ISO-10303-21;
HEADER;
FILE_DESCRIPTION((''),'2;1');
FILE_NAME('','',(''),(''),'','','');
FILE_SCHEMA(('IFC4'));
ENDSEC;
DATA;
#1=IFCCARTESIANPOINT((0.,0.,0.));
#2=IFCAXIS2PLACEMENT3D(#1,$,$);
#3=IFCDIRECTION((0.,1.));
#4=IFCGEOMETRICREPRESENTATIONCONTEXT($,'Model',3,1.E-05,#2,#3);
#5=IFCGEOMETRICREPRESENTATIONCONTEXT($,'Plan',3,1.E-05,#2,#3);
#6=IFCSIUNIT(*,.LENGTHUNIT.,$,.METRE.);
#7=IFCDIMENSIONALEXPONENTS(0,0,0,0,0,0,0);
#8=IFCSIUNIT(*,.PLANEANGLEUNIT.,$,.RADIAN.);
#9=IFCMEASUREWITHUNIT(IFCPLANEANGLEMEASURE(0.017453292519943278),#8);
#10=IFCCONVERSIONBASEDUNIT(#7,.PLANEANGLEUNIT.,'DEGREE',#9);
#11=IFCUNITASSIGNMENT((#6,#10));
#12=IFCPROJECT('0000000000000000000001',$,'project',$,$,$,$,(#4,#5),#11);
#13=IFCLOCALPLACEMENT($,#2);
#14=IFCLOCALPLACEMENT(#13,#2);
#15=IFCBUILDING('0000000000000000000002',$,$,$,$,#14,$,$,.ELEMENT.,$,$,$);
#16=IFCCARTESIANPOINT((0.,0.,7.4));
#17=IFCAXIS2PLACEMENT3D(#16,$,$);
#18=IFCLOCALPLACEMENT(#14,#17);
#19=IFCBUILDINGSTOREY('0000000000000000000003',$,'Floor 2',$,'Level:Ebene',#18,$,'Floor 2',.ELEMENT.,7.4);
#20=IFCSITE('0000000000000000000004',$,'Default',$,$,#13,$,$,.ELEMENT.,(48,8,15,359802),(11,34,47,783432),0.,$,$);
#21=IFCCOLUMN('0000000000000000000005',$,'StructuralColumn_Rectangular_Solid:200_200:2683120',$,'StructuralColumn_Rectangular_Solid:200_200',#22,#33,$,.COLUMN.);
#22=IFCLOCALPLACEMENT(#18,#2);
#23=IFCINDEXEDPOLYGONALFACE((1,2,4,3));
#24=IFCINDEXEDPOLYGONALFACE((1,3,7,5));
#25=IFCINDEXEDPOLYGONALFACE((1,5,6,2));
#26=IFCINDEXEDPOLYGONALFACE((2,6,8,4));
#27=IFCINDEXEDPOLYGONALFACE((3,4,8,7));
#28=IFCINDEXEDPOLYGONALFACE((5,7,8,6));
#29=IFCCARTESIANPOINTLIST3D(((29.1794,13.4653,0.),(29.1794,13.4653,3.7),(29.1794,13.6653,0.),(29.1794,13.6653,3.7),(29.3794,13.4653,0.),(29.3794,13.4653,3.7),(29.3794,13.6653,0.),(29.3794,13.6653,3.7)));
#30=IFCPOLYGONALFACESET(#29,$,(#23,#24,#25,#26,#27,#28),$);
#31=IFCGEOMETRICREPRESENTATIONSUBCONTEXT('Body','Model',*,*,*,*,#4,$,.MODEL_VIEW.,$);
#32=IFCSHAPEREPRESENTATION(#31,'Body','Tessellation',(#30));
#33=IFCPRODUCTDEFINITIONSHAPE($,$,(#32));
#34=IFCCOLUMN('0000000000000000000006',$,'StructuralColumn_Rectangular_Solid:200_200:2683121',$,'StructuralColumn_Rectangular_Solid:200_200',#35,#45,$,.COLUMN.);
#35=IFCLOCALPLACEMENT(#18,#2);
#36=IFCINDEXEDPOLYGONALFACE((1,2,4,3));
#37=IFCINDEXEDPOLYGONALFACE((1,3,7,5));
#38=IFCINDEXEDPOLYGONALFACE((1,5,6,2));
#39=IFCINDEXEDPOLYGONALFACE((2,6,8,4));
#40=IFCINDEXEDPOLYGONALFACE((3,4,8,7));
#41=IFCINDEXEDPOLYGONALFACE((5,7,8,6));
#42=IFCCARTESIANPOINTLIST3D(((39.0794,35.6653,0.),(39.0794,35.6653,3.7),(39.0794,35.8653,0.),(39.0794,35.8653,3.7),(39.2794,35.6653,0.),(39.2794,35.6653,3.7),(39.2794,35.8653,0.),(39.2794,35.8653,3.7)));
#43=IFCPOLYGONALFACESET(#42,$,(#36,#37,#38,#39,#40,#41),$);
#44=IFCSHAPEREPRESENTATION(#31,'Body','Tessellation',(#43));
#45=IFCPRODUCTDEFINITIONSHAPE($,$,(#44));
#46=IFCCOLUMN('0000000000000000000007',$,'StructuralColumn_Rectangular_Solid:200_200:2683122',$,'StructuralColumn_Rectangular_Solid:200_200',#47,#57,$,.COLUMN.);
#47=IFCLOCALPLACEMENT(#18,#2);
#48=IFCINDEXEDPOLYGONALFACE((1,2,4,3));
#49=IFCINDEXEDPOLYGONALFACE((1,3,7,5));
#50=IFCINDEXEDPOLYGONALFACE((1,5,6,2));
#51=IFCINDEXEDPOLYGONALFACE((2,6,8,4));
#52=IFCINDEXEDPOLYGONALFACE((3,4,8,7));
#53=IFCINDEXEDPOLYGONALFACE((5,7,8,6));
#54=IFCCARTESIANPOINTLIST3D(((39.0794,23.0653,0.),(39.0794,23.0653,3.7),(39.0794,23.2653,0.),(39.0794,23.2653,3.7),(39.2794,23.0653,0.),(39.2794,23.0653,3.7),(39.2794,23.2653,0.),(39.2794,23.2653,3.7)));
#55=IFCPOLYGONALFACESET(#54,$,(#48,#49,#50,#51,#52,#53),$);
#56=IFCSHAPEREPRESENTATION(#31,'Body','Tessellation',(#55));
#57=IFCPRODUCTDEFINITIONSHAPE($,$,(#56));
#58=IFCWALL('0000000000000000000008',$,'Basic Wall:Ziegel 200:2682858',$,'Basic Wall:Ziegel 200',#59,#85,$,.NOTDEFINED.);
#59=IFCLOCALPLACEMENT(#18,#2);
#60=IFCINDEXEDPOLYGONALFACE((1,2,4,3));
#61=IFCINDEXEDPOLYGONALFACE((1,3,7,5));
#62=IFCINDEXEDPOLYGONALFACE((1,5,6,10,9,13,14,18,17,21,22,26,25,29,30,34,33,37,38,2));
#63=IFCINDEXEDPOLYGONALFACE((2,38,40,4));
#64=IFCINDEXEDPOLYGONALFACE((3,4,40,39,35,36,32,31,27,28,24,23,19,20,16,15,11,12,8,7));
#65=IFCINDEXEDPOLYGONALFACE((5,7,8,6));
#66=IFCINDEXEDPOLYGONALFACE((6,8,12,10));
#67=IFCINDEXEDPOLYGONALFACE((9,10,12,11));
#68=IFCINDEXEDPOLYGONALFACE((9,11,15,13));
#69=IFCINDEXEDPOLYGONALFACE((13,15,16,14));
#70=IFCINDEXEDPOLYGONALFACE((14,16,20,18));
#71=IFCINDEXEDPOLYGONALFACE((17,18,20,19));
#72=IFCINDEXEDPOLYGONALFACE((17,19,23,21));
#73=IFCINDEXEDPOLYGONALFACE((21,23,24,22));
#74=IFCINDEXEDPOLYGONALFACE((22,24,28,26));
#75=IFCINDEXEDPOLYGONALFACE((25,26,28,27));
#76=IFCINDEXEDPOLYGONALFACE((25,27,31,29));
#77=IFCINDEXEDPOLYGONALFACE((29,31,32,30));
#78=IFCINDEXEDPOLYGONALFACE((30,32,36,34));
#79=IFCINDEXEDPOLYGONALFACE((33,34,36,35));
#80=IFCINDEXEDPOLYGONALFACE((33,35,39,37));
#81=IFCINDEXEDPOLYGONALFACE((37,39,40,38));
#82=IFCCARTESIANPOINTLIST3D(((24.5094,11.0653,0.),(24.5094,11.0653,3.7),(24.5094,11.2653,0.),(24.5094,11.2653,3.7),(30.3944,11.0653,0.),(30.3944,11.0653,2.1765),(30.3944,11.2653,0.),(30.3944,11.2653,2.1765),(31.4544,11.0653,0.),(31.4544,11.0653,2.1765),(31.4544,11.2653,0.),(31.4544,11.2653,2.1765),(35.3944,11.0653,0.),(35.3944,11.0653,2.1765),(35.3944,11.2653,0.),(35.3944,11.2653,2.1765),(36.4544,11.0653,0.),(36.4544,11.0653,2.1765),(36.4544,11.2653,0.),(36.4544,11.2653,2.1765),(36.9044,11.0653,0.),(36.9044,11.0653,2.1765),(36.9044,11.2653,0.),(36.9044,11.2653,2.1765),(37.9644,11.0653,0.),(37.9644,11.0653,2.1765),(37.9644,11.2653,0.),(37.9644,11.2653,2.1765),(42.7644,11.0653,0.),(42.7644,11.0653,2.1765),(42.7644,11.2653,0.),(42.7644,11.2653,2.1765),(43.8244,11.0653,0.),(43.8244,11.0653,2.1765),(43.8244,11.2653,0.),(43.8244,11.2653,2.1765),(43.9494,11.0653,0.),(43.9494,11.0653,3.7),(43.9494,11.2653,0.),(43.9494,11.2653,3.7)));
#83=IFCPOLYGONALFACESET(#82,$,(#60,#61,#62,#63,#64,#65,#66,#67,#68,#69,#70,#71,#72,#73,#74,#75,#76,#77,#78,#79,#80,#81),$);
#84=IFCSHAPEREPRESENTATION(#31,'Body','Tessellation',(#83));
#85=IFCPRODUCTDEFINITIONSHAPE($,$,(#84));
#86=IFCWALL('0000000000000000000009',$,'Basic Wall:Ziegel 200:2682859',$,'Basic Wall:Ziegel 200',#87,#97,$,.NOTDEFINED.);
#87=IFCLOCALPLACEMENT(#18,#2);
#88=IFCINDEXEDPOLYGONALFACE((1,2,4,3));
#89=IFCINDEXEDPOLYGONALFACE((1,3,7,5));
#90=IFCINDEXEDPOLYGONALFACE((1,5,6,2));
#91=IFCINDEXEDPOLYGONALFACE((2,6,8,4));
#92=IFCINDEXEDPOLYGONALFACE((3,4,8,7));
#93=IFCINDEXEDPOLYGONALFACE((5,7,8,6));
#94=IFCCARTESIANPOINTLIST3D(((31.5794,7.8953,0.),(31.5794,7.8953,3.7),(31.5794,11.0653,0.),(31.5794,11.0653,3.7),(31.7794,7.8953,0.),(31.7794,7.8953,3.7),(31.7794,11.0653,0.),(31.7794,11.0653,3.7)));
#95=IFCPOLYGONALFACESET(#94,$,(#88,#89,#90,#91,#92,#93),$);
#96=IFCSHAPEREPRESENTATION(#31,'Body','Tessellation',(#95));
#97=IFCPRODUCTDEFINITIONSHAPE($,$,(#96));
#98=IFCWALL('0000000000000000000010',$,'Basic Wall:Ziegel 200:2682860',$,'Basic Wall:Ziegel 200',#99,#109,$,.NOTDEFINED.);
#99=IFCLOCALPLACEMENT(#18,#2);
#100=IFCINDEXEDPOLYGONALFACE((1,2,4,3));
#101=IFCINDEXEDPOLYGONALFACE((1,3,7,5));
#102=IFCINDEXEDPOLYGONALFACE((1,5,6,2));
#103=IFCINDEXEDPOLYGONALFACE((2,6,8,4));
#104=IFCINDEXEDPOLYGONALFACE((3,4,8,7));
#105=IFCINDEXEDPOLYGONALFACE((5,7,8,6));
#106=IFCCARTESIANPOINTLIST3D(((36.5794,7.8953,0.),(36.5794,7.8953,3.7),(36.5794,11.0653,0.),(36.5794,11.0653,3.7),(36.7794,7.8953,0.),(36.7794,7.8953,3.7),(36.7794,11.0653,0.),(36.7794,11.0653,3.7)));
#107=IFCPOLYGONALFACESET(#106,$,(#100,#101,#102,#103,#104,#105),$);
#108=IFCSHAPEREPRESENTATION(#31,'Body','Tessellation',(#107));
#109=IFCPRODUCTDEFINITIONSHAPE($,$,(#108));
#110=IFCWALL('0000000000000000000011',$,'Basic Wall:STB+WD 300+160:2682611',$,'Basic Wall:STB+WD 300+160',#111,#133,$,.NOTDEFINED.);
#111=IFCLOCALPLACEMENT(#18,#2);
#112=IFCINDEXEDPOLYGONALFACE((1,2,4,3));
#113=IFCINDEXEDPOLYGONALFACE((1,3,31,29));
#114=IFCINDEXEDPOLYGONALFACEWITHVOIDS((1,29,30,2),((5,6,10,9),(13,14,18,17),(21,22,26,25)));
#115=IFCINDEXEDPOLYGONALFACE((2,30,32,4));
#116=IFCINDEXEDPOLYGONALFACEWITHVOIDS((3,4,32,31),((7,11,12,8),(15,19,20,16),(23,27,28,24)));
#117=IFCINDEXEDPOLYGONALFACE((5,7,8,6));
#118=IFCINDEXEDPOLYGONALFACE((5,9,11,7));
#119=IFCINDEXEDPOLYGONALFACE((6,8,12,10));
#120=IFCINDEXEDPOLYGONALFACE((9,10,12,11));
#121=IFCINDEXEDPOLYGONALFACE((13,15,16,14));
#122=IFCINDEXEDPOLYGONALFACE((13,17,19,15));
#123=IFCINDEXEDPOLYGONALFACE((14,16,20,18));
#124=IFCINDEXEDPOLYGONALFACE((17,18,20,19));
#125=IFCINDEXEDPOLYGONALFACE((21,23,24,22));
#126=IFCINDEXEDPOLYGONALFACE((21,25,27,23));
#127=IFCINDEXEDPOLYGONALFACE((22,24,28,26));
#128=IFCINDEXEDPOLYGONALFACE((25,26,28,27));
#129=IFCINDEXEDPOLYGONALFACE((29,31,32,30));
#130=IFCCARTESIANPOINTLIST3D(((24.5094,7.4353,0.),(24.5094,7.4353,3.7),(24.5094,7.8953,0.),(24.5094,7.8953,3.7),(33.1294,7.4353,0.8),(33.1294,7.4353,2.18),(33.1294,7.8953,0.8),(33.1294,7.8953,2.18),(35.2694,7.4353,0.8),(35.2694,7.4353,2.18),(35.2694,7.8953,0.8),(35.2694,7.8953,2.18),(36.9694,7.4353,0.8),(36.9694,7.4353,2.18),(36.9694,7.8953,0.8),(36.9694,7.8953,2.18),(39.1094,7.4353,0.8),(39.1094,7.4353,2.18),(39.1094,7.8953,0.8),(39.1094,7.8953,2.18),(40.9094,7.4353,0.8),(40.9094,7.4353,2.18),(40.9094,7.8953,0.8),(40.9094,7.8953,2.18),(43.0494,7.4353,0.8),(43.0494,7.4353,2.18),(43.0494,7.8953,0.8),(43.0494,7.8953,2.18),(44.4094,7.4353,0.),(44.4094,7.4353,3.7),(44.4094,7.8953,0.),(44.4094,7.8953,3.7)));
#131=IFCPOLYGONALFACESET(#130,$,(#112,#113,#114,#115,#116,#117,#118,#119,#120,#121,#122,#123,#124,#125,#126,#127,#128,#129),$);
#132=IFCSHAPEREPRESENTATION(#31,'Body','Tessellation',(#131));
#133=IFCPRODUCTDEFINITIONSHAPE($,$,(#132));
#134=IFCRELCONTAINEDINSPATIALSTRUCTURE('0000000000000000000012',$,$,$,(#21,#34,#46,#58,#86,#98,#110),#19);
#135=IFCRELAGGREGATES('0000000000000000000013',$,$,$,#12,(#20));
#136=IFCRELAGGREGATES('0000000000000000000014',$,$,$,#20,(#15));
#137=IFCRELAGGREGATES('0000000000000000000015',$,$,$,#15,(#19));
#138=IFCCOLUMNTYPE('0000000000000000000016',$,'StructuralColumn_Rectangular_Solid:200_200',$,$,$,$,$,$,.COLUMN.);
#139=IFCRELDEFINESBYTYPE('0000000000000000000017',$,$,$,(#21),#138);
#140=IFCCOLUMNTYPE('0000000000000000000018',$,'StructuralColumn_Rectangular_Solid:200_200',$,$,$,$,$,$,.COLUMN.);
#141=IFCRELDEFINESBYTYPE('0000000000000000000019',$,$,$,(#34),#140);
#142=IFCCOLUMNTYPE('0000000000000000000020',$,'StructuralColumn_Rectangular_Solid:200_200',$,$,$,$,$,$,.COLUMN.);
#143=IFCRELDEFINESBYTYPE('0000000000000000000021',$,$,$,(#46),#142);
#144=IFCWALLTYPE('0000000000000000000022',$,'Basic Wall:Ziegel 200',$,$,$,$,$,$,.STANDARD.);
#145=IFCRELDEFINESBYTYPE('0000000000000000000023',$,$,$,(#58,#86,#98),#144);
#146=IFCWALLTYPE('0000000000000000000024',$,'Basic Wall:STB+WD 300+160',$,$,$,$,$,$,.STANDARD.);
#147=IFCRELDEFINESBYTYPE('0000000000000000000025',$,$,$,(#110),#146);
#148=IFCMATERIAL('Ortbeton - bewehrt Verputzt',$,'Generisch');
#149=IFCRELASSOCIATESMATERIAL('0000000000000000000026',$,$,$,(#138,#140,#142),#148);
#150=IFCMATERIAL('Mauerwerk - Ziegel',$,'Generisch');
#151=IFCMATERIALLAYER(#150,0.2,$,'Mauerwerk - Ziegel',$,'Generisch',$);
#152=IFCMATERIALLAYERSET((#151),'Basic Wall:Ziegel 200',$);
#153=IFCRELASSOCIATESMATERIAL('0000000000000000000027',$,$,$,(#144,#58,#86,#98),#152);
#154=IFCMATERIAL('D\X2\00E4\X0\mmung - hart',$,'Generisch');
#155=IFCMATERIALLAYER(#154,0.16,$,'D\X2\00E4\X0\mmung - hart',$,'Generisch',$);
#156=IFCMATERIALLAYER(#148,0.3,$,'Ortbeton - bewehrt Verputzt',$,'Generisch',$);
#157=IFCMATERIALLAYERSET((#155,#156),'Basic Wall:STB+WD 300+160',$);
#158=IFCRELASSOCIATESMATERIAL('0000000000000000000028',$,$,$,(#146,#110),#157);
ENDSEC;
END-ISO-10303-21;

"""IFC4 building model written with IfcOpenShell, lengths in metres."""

from ifc_helpers import new_model, entity, si_unit, converted_unit, direction, frame, frame_2d, origin, place, context, subcontext, project, spatial, rectangle, extrude, source, transform, mapped, material, layer, layer_set, layer_usage, material_profile, profile_set, type_object, type_shapes, element, save


model = new_model("IFC4")

# Units and contexts
model_context = context("Model", 3, precision=1e-05, world=origin(), true_north=direction((0.0, 1.0)))
plan_context = context("Plan", 3, precision=1e-05, world=origin(), true_north=direction((0.0, 1.0)))
body_context = subcontext(model_context, "Body", "Model", "MODEL_VIEW")
ifc_project = project(units=[si_unit("LENGTHUNIT", "METRE"), converted_unit("PLANEANGLEUNIT", "DEGREE", entity("IfcPlaneAngleMeasure", 0.017453292519943278), si_unit("PLANEANGLEUNIT", "RADIAN"), dimensions=[0, 0, 0, 0, 0, 0, 0])], contexts=[model_context, plan_context])

# Site, building, storey
site_placement = place(None, origin())
site = spatial("IfcSite", under=ifc_project, at=site_placement, Name="Default", CompositionType="ELEMENT", RefLatitude=(48, 8, 15, 359802), RefLongitude=(11, 34, 47, 783432), RefElevation=0.0)
building_placement = place(site_placement, origin())
building = spatial("IfcBuilding", under=site, at=building_placement, CompositionType="ELEMENT")
storey_placement = place(building_placement, frame((0.0, 0.0, 7.4)))
storey = spatial("IfcBuildingStorey", under=building, at=storey_placement, Name="Floor 2", ObjectType="Level:Ebene", LongName="Floor 2", CompositionType="ELEMENT", Elevation=7.4)

# Columns
ifc_material_1 = material(Name="Ortbeton - bewehrt Verputzt", Category="Generisch")
ifc_material_profile = material_profile(ifc_material_1, rectangle(XDim=0.2, YDim=0.2, at=frame_2d((0.0, 0.0), x_axis=(1.0, 0.0))), Name="200_200")
ifc_profile_set = profile_set([ifc_material_profile], Name="200_200")
column_type_1 = type_object("IfcColumnType", Name="StructuralColumn_Rectangular_Solid:200_200", PredefinedType="COLUMN", material=ifc_profile_set)
shared_shape_1 = source(origin(), body_context, "Body", "SweptSolid", [
    extrude(rectangle(XDim=0.2, YDim=0.2, at=frame_2d((0.0, 0.0), x_axis=(1.0, 0.0))), frame((29.2794, 13.5653, 7.4), z_axis=(0.0, 0.0, 1.0), x_axis=(-1.0, 0.0, 0.0)), (0.0, 0.0, 1.0), 3.7),
])
type_shapes(column_type_1, [shared_shape_1])
column_1_placement = place(storey_placement, frame((0.0, 0.0, -7.4)))
element("IfcColumn", 1, at=column_1_placement, inside=storey, type_object=column_type_1, Name="StructuralColumn_Rectangular_Solid:200_200:2683120", ObjectType="StructuralColumn_Rectangular_Solid:200_200", PredefinedType="COLUMN", context=body_context, shape_type="MappedRepresentation", body=[
    mapped(shared_shape_1, transform((0.0, 0.0, 0.0), scale=1.0)),
])
column_type_2 = type_object("IfcColumnType", Name="StructuralColumn_Rectangular_Solid:200_200", PredefinedType="COLUMN", material=ifc_profile_set)
shared_shape_2 = source(origin(), body_context, "Body", "SweptSolid", [
    extrude(rectangle(XDim=0.2, YDim=0.2, at=frame_2d((0.0, 0.0), x_axis=(1.0, 0.0))), frame((39.1794, 35.7653, 7.4), z_axis=(0.0, 0.0, 1.0), x_axis=(-1.0, 0.0, 0.0)), (0.0, 0.0, 1.0), 3.7),
])
type_shapes(column_type_2, [shared_shape_2])
column_2_placement = place(storey_placement, frame((0.0, 0.0, -7.4)))
element("IfcColumn", 2, at=column_2_placement, inside=storey, type_object=column_type_2, Name="StructuralColumn_Rectangular_Solid:200_200:2683121", ObjectType="StructuralColumn_Rectangular_Solid:200_200", PredefinedType="COLUMN", context=body_context, shape_type="MappedRepresentation", body=[
    mapped(shared_shape_2, transform((0.0, 0.0, 0.0), scale=1.0)),
])
column_type_3 = type_object("IfcColumnType", Name="StructuralColumn_Rectangular_Solid:200_200", PredefinedType="COLUMN", material=ifc_profile_set)
shared_shape_3 = source(origin(), body_context, "Body", "SweptSolid", [
    extrude(rectangle(XDim=0.2, YDim=0.2, at=frame_2d((0.0, 0.0), x_axis=(1.0, 0.0))), frame((39.1794, 23.1653, 7.4), z_axis=(0.0, 0.0, 1.0), x_axis=(-1.0, 0.0, 0.0)), (0.0, 0.0, 1.0), 3.7),
])
type_shapes(column_type_3, [shared_shape_3])
column_3_placement = place(storey_placement, frame((0.0, 0.0, -7.4)))
element("IfcColumn", 3, at=column_3_placement, inside=storey, type_object=column_type_3, Name="StructuralColumn_Rectangular_Solid:200_200:2683122", ObjectType="StructuralColumn_Rectangular_Solid:200_200", PredefinedType="COLUMN", context=body_context, shape_type="MappedRepresentation", body=[
    mapped(shared_shape_3, transform((0.0, 0.0, 0.0), scale=1.0)),
])

# Wall, openings
ifc_material_2 = material(Name="Mauerwerk - Ziegel", Category="Generisch")
ifc_layer_1 = layer(ifc_material_2, 0.2, Name="Mauerwerk - Ziegel", Category="Generisch")
ifc_layer_set_1 = layer_set([ifc_layer_1], Name="Basic Wall:Ziegel 200")
ifc_layer_usage_1 = layer_usage(ifc_layer_set_1, "AXIS2", "NEGATIVE", 0.1)
wall_type_1 = type_object("IfcWallType", Name="Basic Wall:Ziegel 200", PredefinedType="STANDARD", material=ifc_layer_set_1)
wall_1_placement = place(storey_placement, frame((43.9494, 11.1653, 0.0), z_axis=(0.0, 0.0, 1.0), x_axis=(-1.0, 0.0, 0.0)))
wall_1 = element("IfcWall", 4, at=wall_1_placement, inside=storey, type_object=wall_type_1, material=ifc_layer_usage_1, Name="Basic Wall:Ziegel 200:2682858", ObjectType="Basic Wall:Ziegel 200", PredefinedType="NOTDEFINED", context=body_context, shape_type="SweptSolid", body=[
    extrude(rectangle(XDim=19.44, YDim=0.2, at=frame_2d((9.72, 0.0), x_axis=(1.0, 0.0))), origin(), (0.0, 0.0, 1.0), 3.7),
])
opening_1_placement = place(wall_1_placement, frame((13.555, 0.1, 0.0)))
element("IfcOpeningElement", 5, at=opening_1_placement, cuts=wall_1, PredefinedType="OPENING", context=body_context, shape_type="SweptSolid", body=[
    extrude(rectangle(XDim=2.1765, YDim=1.06, at=frame_2d((1.0882, 0.53), x_axis=(1.0, 0.0))), frame((0.0, 0.0, 0.0), z_axis=(0.0, -1.0, 0.0), x_axis=(0.0, 0.0, 1.0)), (0.0, 0.0, 1.0), 0.2),
])
opening_2_placement = place(wall_1_placement, frame((8.555, 0.1, 0.0)))
element("IfcOpeningElement", 6, at=opening_2_placement, cuts=wall_1, PredefinedType="OPENING", context=body_context, shape_type="SweptSolid", body=[
    extrude(rectangle(XDim=2.1765, YDim=1.06, at=frame_2d((1.0882, 0.53), x_axis=(1.0, 0.0))), frame((0.0, 0.0, 0.0), z_axis=(0.0, -1.0, 0.0), x_axis=(0.0, 0.0, 1.0)), (0.0, 0.0, 1.0), 0.2),
])
opening_3_placement = place(wall_1_placement, frame((7.045, 0.1, 0.0)))
element("IfcOpeningElement", 7, at=opening_3_placement, cuts=wall_1, PredefinedType="OPENING", context=body_context, shape_type="SweptSolid", body=[
    extrude(rectangle(XDim=2.1765, YDim=1.06, at=frame_2d((1.0882, 0.53), x_axis=(1.0, 0.0))), frame((0.0, 0.0, 0.0), z_axis=(0.0, -1.0, 0.0), x_axis=(0.0, 0.0, 1.0)), (0.0, 0.0, 1.0), 0.2),
])
opening_4_placement = place(wall_1_placement, frame((1.185, 0.1, 0.0)))
element("IfcOpeningElement", 8, at=opening_4_placement, cuts=wall_1, PredefinedType="OPENING", context=body_context, shape_type="SweptSolid", body=[
    extrude(rectangle(XDim=2.1765, YDim=1.06, at=frame_2d((1.0882, 0.53), x_axis=(1.0, 0.0))), frame((0.0, 0.0, 0.0), z_axis=(0.0, -1.0, 0.0), x_axis=(0.0, 0.0, 1.0)), (0.0, 0.0, 1.0), 0.2),
])

# Walls
wall_2_placement = place(storey_placement, frame((31.6794, 11.0653, 0.0), z_axis=(0.0, 0.0, 1.0), x_axis=(0.0, -1.0, 0.0)))
element("IfcWall", 9, at=wall_2_placement, inside=storey, type_object=wall_type_1, material=ifc_layer_usage_1, Name="Basic Wall:Ziegel 200:2682859", ObjectType="Basic Wall:Ziegel 200", PredefinedType="NOTDEFINED", context=body_context, shape_type="SweptSolid", body=[
    extrude(rectangle(XDim=3.17, YDim=0.2, at=frame_2d((1.585, 0.0), x_axis=(-1.0, 0.0))), origin(), (0.0, 0.0, 1.0), 3.7),
])
wall_3_placement = place(storey_placement, frame((36.6794, 11.0653, 0.0), z_axis=(0.0, 0.0, 1.0), x_axis=(0.0, -1.0, 0.0)))
element("IfcWall", 10, at=wall_3_placement, inside=storey, type_object=wall_type_1, material=ifc_layer_usage_1, Name="Basic Wall:Ziegel 200:2682860", ObjectType="Basic Wall:Ziegel 200", PredefinedType="NOTDEFINED", context=body_context, shape_type="SweptSolid", body=[
    extrude(rectangle(XDim=3.17, YDim=0.2, at=frame_2d((1.585, 0.0), x_axis=(-1.0, 0.0))), origin(), (0.0, 0.0, 1.0), 3.7),
])

# Wall, openings
ifc_material_3 = material(Name="Dämmung - hart", Category="Generisch")
ifc_layer_2 = layer(ifc_material_3, 0.16, Name="Dämmung - hart", Category="Generisch")
ifc_layer_3 = layer(ifc_material_1, 0.3, Name="Ortbeton - bewehrt Verputzt", Category="Generisch")
ifc_layer_set_2 = layer_set([ifc_layer_2, ifc_layer_3], Name="Basic Wall:STB+WD 300+160")
ifc_layer_usage_2 = layer_usage(ifc_layer_set_2, "AXIS2", "POSITIVE", -0.23)
wall_type_2 = type_object("IfcWallType", Name="Basic Wall:STB+WD 300+160", PredefinedType="STANDARD", material=ifc_layer_set_2)
wall_4_placement = place(storey_placement, frame((24.5094, 7.6653, 0.0)))
wall_4 = element("IfcWall", 11, at=wall_4_placement, inside=storey, type_object=wall_type_2, material=ifc_layer_usage_2, Name="Basic Wall:STB+WD 300+160:2682611", ObjectType="Basic Wall:STB+WD 300+160", PredefinedType="NOTDEFINED", context=body_context, shape_type="SweptSolid", body=[
    extrude(rectangle(XDim=19.9, YDim=0.46, at=frame_2d((9.95, 0.0), x_axis=(-1.0, 0.0))), origin(), (0.0, 0.0, 1.0), 3.7),
])
opening_5_placement = place(wall_4_placement, frame((-24.5094, -7.6653, 0.8)))
element("IfcOpeningElement", 12, at=opening_5_placement, cuts=wall_4, PredefinedType="OPENING", context=body_context, shape_type="SweptSolid", body=[
    extrude(rectangle(XDim=1.38, YDim=2.14, at=frame_2d((0.0, 0.0), x_axis=(0.0, 1.0))), frame((34.1994, 6.3713, 0.69), z_axis=(0.0, 1.0, 0.0), x_axis=(-1.0, 0.0, 0.0)), (0.0, 0.0, 1.0), 3.048),
])
opening_6_placement = place(wall_4_placement, frame((-24.5094, -7.6653, 0.8)))
element("IfcOpeningElement", 13, at=opening_6_placement, cuts=wall_4, PredefinedType="OPENING", context=body_context, shape_type="SweptSolid", body=[
    extrude(rectangle(XDim=1.38, YDim=2.14, at=frame_2d((0.0, 0.0), x_axis=(0.0, 1.0))), frame((38.0394, 6.3713, 0.69), z_axis=(0.0, 1.0, 0.0), x_axis=(-1.0, 0.0, 0.0)), (0.0, 0.0, 1.0), 3.048),
])
opening_7_placement = place(wall_4_placement, frame((-24.5094, -7.6653, 0.8)))
element("IfcOpeningElement", 14, at=opening_7_placement, cuts=wall_4, PredefinedType="OPENING", context=body_context, shape_type="SweptSolid", body=[
    extrude(rectangle(XDim=1.38, YDim=2.14, at=frame_2d((0.0, 0.0), x_axis=(0.0, 1.0))), frame((41.9794, 6.3713, 0.69), z_axis=(0.0, 1.0, 0.0), x_axis=(-1.0, 0.0, 0.0)), (0.0, 0.0, 1.0), 3.048),
])

save(model, "model.ifc")
